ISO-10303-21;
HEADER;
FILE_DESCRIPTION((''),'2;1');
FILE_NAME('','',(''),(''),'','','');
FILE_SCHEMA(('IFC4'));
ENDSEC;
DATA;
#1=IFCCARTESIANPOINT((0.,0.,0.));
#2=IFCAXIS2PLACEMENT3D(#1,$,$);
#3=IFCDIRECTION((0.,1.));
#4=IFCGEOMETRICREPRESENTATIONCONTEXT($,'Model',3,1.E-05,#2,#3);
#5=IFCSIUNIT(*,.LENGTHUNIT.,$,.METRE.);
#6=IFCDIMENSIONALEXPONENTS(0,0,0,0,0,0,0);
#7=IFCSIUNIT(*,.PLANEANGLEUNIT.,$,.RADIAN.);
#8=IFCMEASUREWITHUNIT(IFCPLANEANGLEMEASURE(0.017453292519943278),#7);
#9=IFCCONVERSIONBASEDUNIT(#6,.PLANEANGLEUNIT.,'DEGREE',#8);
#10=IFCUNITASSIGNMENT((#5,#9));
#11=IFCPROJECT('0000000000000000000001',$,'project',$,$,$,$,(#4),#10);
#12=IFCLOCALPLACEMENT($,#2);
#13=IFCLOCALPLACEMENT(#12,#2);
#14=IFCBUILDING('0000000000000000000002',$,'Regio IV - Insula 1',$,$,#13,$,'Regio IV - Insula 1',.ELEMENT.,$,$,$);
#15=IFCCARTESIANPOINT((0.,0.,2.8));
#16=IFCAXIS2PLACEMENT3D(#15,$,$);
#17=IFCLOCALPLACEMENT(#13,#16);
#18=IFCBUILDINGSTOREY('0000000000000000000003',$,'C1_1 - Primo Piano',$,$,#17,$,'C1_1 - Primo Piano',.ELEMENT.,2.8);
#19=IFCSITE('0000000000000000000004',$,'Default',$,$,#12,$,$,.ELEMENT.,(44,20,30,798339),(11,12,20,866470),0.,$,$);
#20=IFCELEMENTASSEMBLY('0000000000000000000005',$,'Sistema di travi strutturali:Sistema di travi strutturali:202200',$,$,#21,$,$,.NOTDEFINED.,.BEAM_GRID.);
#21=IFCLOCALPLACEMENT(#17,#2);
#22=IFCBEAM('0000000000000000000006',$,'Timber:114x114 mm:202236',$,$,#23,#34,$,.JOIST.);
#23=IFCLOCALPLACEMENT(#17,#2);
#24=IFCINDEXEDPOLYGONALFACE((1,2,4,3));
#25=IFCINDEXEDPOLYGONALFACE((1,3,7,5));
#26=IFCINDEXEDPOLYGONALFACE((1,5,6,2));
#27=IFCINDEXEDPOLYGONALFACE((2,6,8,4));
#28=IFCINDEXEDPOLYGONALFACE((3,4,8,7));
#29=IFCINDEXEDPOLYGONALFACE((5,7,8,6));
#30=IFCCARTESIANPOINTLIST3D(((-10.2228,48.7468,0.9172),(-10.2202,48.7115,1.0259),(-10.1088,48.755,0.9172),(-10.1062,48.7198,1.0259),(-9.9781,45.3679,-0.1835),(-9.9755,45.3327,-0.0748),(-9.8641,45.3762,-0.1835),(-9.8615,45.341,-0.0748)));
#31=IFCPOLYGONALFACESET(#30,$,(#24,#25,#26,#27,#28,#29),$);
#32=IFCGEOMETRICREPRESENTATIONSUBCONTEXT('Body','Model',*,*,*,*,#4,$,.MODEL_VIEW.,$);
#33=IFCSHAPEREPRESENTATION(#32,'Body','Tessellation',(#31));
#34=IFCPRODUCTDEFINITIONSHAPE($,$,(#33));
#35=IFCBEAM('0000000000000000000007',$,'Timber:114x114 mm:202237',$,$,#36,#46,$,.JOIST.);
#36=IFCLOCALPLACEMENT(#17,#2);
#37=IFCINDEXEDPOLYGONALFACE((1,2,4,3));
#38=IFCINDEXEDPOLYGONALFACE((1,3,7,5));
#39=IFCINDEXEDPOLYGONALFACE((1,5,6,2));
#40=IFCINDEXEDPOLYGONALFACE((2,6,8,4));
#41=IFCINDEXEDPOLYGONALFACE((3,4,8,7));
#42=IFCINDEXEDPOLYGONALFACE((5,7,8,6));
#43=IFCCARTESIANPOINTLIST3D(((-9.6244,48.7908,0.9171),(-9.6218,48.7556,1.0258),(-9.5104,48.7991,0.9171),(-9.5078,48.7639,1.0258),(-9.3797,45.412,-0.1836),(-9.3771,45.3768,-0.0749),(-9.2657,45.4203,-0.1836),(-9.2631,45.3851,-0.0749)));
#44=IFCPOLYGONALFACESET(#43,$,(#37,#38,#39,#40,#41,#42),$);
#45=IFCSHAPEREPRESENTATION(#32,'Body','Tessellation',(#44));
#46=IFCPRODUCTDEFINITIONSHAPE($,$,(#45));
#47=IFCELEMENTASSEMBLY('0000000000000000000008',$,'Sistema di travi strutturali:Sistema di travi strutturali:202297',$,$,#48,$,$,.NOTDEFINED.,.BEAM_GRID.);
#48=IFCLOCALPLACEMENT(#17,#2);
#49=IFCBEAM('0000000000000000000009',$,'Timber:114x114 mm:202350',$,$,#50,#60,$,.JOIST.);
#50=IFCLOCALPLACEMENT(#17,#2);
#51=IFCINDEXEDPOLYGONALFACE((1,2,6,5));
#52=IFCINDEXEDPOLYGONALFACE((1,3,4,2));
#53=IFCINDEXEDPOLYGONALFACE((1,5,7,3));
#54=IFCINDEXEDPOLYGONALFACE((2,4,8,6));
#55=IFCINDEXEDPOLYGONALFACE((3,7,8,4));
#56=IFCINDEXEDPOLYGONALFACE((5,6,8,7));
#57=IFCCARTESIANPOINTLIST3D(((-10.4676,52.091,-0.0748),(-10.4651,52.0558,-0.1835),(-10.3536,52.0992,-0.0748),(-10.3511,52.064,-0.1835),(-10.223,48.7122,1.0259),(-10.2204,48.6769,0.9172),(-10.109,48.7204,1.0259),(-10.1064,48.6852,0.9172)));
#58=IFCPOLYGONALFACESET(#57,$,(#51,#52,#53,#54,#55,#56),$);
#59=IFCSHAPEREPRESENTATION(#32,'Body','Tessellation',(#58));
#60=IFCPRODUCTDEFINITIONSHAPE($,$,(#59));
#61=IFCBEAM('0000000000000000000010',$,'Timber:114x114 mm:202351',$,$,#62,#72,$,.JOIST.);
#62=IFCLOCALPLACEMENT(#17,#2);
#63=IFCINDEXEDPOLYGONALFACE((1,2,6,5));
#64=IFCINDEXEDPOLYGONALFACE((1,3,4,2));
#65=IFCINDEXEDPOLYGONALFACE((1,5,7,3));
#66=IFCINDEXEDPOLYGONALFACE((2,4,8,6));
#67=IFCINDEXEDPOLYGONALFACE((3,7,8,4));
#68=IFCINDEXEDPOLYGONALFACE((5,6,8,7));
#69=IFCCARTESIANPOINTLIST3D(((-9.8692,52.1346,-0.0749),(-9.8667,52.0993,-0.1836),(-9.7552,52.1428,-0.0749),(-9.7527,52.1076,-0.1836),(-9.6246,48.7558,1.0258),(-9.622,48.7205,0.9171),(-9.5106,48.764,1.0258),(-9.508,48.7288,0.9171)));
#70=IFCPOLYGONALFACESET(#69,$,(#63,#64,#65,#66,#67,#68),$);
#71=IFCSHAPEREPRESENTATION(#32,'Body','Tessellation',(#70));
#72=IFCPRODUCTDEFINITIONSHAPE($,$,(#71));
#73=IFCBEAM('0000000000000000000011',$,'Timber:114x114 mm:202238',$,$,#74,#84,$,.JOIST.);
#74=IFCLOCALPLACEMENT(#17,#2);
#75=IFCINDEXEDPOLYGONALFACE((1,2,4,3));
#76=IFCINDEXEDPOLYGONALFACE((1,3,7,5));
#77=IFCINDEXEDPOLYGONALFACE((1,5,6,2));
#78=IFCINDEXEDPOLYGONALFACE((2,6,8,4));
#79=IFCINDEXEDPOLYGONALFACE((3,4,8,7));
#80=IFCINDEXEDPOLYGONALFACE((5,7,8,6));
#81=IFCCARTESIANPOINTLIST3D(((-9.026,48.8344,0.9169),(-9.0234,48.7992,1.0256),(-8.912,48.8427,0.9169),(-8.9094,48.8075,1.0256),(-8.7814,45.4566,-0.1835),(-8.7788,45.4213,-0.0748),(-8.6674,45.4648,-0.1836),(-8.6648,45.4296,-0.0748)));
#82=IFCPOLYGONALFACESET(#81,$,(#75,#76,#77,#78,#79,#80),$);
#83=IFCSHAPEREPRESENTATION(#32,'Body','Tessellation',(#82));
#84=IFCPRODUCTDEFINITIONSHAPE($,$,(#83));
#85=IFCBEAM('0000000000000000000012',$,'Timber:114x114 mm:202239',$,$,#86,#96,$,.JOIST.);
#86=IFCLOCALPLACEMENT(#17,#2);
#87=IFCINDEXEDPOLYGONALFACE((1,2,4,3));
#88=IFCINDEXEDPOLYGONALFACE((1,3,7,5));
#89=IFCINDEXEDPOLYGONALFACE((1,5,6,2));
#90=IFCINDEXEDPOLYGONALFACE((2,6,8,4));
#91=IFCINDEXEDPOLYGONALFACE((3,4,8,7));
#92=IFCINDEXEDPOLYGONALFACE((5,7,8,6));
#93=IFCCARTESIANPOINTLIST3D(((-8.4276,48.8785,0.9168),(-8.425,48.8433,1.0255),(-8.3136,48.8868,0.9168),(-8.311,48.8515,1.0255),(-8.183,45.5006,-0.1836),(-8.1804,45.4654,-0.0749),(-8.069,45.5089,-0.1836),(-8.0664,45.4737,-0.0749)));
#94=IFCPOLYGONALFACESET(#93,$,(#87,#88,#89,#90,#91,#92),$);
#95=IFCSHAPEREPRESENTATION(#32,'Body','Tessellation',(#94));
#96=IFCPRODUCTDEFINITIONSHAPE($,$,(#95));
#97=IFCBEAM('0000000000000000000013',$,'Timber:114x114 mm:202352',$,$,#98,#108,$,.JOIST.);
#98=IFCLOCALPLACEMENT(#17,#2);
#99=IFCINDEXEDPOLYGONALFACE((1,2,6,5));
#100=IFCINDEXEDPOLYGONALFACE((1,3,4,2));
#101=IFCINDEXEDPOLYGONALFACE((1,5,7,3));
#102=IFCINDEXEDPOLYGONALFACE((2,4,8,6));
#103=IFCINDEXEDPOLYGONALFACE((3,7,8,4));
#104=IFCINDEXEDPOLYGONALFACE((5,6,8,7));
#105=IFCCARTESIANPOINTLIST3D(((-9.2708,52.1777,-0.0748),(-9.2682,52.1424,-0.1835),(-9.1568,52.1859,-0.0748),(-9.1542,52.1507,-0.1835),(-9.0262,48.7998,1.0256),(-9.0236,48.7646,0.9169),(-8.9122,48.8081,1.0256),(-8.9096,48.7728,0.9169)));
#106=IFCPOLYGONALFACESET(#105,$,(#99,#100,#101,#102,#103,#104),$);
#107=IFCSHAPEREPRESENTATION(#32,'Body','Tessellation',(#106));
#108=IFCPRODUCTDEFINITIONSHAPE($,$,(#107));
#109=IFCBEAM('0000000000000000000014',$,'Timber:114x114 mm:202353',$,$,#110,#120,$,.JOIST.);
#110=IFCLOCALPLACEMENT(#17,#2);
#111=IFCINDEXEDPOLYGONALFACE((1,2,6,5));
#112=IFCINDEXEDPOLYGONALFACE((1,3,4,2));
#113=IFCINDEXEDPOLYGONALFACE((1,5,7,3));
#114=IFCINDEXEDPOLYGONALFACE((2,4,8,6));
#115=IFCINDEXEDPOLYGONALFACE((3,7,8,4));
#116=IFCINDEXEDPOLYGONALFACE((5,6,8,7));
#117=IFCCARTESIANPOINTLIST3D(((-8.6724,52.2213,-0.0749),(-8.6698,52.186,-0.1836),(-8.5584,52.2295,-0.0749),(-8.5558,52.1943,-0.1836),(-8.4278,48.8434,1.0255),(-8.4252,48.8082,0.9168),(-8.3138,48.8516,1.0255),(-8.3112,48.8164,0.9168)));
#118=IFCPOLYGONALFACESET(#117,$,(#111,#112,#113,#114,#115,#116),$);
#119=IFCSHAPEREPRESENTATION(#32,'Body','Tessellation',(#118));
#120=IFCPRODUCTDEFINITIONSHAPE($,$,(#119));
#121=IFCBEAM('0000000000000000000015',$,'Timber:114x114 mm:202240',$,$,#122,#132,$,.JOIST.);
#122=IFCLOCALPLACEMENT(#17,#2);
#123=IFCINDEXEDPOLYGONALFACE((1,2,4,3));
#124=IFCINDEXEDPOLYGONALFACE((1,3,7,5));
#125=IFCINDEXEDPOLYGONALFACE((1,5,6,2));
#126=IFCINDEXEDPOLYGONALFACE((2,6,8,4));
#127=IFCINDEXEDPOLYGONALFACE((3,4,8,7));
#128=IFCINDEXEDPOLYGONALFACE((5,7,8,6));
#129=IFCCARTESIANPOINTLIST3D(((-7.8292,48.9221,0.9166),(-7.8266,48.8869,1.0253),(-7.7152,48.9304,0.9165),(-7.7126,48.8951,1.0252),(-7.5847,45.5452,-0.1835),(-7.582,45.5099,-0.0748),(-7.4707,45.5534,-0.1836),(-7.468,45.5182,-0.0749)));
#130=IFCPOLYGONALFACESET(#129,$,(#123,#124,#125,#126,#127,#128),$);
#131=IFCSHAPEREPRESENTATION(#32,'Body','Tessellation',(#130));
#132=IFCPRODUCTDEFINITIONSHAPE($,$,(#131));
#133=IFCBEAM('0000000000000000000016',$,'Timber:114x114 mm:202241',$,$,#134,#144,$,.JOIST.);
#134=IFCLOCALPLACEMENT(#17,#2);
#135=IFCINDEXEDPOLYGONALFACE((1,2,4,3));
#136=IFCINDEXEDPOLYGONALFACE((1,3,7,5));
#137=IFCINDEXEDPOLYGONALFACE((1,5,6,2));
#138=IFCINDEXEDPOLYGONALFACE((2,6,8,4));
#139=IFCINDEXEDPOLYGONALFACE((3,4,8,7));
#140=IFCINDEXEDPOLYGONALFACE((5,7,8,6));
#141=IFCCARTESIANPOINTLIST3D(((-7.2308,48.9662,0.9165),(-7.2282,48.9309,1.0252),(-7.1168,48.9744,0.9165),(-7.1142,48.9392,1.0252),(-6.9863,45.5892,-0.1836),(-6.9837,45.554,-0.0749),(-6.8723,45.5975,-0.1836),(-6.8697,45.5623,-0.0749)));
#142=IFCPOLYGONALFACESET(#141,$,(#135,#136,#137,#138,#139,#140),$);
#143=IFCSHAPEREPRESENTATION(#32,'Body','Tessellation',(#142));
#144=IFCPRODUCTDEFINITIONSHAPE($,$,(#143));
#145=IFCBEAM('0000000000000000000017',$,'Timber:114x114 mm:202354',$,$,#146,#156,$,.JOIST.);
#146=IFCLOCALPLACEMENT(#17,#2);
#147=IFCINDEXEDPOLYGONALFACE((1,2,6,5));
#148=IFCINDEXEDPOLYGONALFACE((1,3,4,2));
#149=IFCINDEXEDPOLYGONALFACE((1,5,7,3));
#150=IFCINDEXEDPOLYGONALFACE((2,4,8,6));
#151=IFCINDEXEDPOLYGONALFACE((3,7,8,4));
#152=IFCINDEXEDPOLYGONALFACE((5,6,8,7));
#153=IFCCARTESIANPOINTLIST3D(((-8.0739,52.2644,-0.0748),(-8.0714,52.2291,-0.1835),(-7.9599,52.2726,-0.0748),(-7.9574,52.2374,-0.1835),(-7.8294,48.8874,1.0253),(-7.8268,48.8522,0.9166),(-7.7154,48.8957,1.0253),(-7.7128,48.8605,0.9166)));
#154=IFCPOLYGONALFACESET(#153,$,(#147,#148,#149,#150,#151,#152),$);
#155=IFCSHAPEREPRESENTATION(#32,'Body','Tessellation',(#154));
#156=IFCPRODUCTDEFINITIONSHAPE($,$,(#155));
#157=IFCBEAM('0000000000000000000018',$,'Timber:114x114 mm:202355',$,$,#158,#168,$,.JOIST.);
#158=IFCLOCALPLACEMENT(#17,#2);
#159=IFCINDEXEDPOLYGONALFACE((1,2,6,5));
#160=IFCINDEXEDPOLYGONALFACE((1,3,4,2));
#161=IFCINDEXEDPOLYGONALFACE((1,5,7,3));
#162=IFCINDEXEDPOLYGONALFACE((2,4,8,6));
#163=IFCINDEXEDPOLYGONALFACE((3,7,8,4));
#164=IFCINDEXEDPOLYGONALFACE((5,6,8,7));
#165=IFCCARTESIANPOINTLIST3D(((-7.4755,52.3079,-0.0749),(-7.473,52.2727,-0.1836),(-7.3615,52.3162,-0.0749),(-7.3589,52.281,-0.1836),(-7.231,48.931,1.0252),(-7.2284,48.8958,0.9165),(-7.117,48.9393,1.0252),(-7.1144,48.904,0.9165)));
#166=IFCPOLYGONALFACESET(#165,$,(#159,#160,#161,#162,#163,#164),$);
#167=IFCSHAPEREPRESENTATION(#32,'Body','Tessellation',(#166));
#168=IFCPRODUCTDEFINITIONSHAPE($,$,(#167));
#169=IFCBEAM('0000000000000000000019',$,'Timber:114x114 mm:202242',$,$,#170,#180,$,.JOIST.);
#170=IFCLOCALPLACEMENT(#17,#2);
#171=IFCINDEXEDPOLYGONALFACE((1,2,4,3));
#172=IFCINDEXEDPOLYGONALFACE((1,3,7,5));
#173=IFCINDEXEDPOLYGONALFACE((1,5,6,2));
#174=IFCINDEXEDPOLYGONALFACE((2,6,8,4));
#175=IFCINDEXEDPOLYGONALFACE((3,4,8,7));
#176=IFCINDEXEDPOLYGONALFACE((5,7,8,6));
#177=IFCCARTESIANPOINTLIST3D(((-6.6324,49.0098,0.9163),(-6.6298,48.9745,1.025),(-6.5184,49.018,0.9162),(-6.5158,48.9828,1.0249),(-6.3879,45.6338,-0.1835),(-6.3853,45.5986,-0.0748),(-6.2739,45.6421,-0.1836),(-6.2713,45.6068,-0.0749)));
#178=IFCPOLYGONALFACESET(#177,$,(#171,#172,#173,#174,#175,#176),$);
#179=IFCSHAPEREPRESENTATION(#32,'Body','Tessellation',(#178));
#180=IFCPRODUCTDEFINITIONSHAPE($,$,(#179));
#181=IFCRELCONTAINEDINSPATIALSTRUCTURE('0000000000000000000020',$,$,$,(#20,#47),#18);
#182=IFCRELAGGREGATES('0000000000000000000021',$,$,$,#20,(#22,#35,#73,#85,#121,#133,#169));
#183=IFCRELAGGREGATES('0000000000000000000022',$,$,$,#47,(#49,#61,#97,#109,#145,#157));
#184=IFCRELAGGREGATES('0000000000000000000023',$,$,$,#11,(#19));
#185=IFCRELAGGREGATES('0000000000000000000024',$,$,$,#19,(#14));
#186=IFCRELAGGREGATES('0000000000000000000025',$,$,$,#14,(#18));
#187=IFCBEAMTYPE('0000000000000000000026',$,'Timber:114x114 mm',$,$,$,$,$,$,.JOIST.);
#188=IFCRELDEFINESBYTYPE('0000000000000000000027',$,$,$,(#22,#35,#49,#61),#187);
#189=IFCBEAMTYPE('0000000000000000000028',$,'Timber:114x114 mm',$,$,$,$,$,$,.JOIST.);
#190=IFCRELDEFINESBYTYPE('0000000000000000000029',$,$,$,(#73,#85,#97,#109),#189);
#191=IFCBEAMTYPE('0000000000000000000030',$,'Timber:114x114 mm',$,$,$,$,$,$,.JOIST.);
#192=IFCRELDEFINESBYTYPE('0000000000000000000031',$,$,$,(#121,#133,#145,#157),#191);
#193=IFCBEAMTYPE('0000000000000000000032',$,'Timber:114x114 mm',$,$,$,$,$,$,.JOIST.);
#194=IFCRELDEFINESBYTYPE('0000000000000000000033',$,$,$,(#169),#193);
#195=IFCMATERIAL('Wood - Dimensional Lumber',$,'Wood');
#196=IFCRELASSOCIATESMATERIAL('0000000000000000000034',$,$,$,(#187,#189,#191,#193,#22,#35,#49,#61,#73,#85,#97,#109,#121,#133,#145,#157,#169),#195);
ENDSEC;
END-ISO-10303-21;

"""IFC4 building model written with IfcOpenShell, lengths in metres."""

from ifc_helpers import new_model, entity, si_unit, converted_unit, direction, frame, origin, origin_2d_with_axis, place, context, subcontext, project, spatial, rectangle, extrude, source, transform, mapped, material, material_profile, profile_set, profile_usage, type_object, type_shapes, element, aggregate, save


model = new_model("IFC4")

# Units and contexts
model_context = context("Model", 3, precision=1e-05, world=origin(), true_north=direction((0.0, 1.0)))
body_context = subcontext(model_context, "Body", "Model", "MODEL_VIEW")
ifc_project = project(units=[si_unit("LENGTHUNIT", "METRE"), converted_unit("PLANEANGLEUNIT", "DEGREE", entity("IfcPlaneAngleMeasure", 0.017453292519943278), si_unit("PLANEANGLEUNIT", "RADIAN"), dimensions=[0, 0, 0, 0, 0, 0, 0])], contexts=[model_context])

# Site, building, storey
site_placement = place(None, origin())
site = spatial("IfcSite", under=ifc_project, at=site_placement, Name="Default", CompositionType="ELEMENT", RefLatitude=(44, 20, 30, 798339), RefLongitude=(11, 12, 20, 866470), RefElevation=0.0)
building_placement = place(site_placement, origin())
building = spatial("IfcBuilding", under=site, at=building_placement, Name="Regio IV - Insula 1", LongName="Regio IV - Insula 1", CompositionType="ELEMENT")
storey_placement = place(building_placement, frame((0.0, 0.0, 2.8)))
storey = spatial("IfcBuildingStorey", under=building, at=storey_placement, Name="C1_1 - Primo Piano", LongName="C1_1 - Primo Piano", CompositionType="ELEMENT", Elevation=2.8)

# Element assemblies, beams
assembly_1_placement = place(storey_placement, origin())
assembly_1 = element("IfcElementAssembly", 1, at=assembly_1_placement, inside=storey, Name="Sistema di travi strutturali:Sistema di travi strutturali:202200", AssemblyPlace="NOTDEFINED", PredefinedType="BEAM_GRID")
ifc_material = material(Name="Wood - Dimensional Lumber", Category="Wood")
ifc_material_profile = material_profile(ifc_material, rectangle(XDim=5.294, YDim=0.1143, at=origin_2d_with_axis()), Name="114x114 mm")
ifc_profile_set = profile_set([ifc_material_profile], Name="114x114 mm")
ifc_profile_usage = profile_usage(ifc_profile_set, cardinal=8)
beam_type_1 = type_object("IfcBeamType", Name="Timber:114x114 mm", PredefinedType="JOIST", material=ifc_profile_set)
shared_shape_1 = source(origin(), body_context, "Body", "SweptSolid", [
    extrude(rectangle(XDim=3.562, YDim=0.1143, at=origin_2d_with_axis()), frame((0.0, 0.0, -0.0572), z_axis=(0.0, 0.0, 1.0), x_axis=(-1.0, 0.0, 0.0)), (0.0, 0.0, 1.0), 0.1143),
])
type_shapes(beam_type_1, [shared_shape_1])
beam_1_placement = place(assembly_1_placement, frame((-10.0421, 47.0439, 0.4212), z_axis=(0.022823, -0.308173, 0.951057), x_axis=(0.068685, -0.948573, -0.309017)))
beam_1 = element("IfcBeam", 2, at=beam_1_placement, type_object=beam_type_1, material=ifc_profile_usage, Name="Timber:114x114 mm:202236", PredefinedType="JOIST", context=body_context, shape_type="MappedRepresentation", body=[
    mapped(shared_shape_1, transform((0.0, 0.0, 0.0), scale=1.0)),
])
beam_2_placement = place(assembly_1_placement, frame((-9.4438, 47.088, 0.4211), z_axis=(0.022823, -0.308173, 0.951057), x_axis=(0.068685, -0.948573, -0.309017)))
beam_2 = element("IfcBeam", 3, at=beam_2_placement, type_object=beam_type_1, material=ifc_profile_usage, Name="Timber:114x114 mm:202237", PredefinedType="JOIST", context=body_context, shape_type="MappedRepresentation", body=[
    mapped(shared_shape_1, transform((0.0, 0.0, 0.0), scale=1.0)),
])
assembly_2_placement = place(storey_placement, origin())
assembly_2 = element("IfcElementAssembly", 4, at=assembly_2_placement, inside=storey, Name="Sistema di travi strutturali:Sistema di travi strutturali:202297", AssemblyPlace="NOTDEFINED", PredefinedType="BEAM_GRID")
beam_3_placement = place(assembly_2_placement, frame((-10.287, 50.3881, 0.4212), z_axis=(-0.022317, 0.30821, 0.951057), x_axis=(0.068685, -0.948573, 0.309017)))
beam_3 = element("IfcBeam", 5, at=beam_3_placement, type_object=beam_type_1, material=ifc_profile_usage, Name="Timber:114x114 mm:202350", PredefinedType="JOIST", context=body_context, shape_type="MappedRepresentation", body=[
    mapped(shared_shape_1, transform((0.0, 0.0, 0.0), scale=1.0)),
])
beam_4_placement = place(assembly_2_placement, frame((-9.6886, 50.4317, 0.4211), z_axis=(-0.022317, 0.30821, 0.951057), x_axis=(0.068685, -0.948573, 0.309017)))
beam_4 = element("IfcBeam", 6, at=beam_4_placement, type_object=beam_type_1, material=ifc_profile_usage, Name="Timber:114x114 mm:202351", PredefinedType="JOIST", context=body_context, shape_type="MappedRepresentation", body=[
    mapped(shared_shape_1, transform((0.0, 0.0, 0.0), scale=1.0)),
])

# Beams
beam_type_2 = type_object("IfcBeamType", Name="Timber:114x114 mm", PredefinedType="JOIST", material=ifc_profile_set)
shared_shape_2 = source(origin(), body_context, "Body", "SweptSolid", [
    extrude(rectangle(XDim=3.561, YDim=0.1143, at=origin_2d_with_axis()), frame((0.0, 0.0, -0.0572), z_axis=(0.0, 0.0, 1.0), x_axis=(-1.0, 0.0, 0.0)), (0.0, 0.0, 1.0), 0.1143),
])
type_shapes(beam_type_2, [shared_shape_2])
beam_5_placement = place(assembly_1_placement, frame((-8.8454, 47.132, 0.421), z_axis=(0.022823, -0.308173, 0.951057), x_axis=(0.068685, -0.948573, -0.309017)))
beam_5 = element("IfcBeam", 7, at=beam_5_placement, type_object=beam_type_2, material=ifc_profile_usage, Name="Timber:114x114 mm:202238", PredefinedType="JOIST", context=body_context, shape_type="MappedRepresentation", body=[
    mapped(shared_shape_2, transform((0.0, 0.0, 0.0), scale=1.0)),
])
beam_6_placement = place(assembly_1_placement, frame((-8.247, 47.1761, 0.4209), z_axis=(0.022823, -0.308173, 0.951057), x_axis=(0.068685, -0.948573, -0.309017)))
beam_6 = element("IfcBeam", 8, at=beam_6_placement, type_object=beam_type_2, material=ifc_profile_usage, Name="Timber:114x114 mm:202239", PredefinedType="JOIST", context=body_context, shape_type="MappedRepresentation", body=[
    mapped(shared_shape_2, transform((0.0, 0.0, 0.0), scale=1.0)),
])
beam_7_placement = place(assembly_2_placement, frame((-9.0902, 50.4753, 0.421), z_axis=(-0.022317, 0.30821, 0.951057), x_axis=(0.068685, -0.948573, 0.309017)))
beam_7 = element("IfcBeam", 9, at=beam_7_placement, type_object=beam_type_2, material=ifc_profile_usage, Name="Timber:114x114 mm:202352", PredefinedType="JOIST", context=body_context, shape_type="MappedRepresentation", body=[
    mapped(shared_shape_2, transform((0.0, 0.0, 0.0), scale=1.0)),
])
beam_8_placement = place(assembly_2_placement, frame((-8.4918, 50.5188, 0.4209), z_axis=(-0.022317, 0.30821, 0.951057), x_axis=(0.068685, -0.948573, 0.309017)))
beam_8 = element("IfcBeam", 10, at=beam_8_placement, type_object=beam_type_2, material=ifc_profile_usage, Name="Timber:114x114 mm:202353", PredefinedType="JOIST", context=body_context, shape_type="MappedRepresentation", body=[
    mapped(shared_shape_2, transform((0.0, 0.0, 0.0), scale=1.0)),
])
beam_type_3 = type_object("IfcBeamType", Name="Timber:114x114 mm", PredefinedType="JOIST", material=ifc_profile_set)
shared_shape_3 = source(origin(), body_context, "Body", "SweptSolid", [
    extrude(rectangle(XDim=3.56, YDim=0.1143, at=origin_2d_with_axis()), frame((0.0, 0.0, -0.0572), z_axis=(0.0, 0.0, 1.0), x_axis=(-1.0, 0.0, 0.0)), (0.0, 0.0, 1.0), 0.1143),
])
type_shapes(beam_type_3, [shared_shape_3])
beam_9_placement = place(assembly_1_placement, frame((-7.6486, 47.2202, 0.4209), z_axis=(0.022823, -0.308173, 0.951057), x_axis=(0.068685, -0.948573, -0.309017)))
beam_9 = element("IfcBeam", 11, at=beam_9_placement, type_object=beam_type_3, material=ifc_profile_usage, Name="Timber:114x114 mm:202240", PredefinedType="JOIST", context=body_context, shape_type="MappedRepresentation", body=[
    mapped(shared_shape_3, transform((0.0, 0.0, 0.0), scale=1.0)),
])
beam_10_placement = place(assembly_1_placement, frame((-7.0502, 47.2642, 0.4208), z_axis=(0.022823, -0.308173, 0.951057), x_axis=(0.068685, -0.948573, -0.309017)))
beam_10 = element("IfcBeam", 12, at=beam_10_placement, type_object=beam_type_3, material=ifc_profile_usage, Name="Timber:114x114 mm:202241", PredefinedType="JOIST", context=body_context, shape_type="MappedRepresentation", body=[
    mapped(shared_shape_3, transform((0.0, 0.0, 0.0), scale=1.0)),
])
beam_11_placement = place(assembly_2_placement, frame((-7.8934, 50.5624, 0.4209), z_axis=(-0.022317, 0.30821, 0.951057), x_axis=(0.068685, -0.948573, 0.309017)))
beam_11 = element("IfcBeam", 13, at=beam_11_placement, type_object=beam_type_3, material=ifc_profile_usage, Name="Timber:114x114 mm:202354", PredefinedType="JOIST", context=body_context, shape_type="MappedRepresentation", body=[
    mapped(shared_shape_3, transform((0.0, 0.0, 0.0), scale=1.0)),
])
beam_12_placement = place(assembly_2_placement, frame((-7.295, 50.606, 0.4208), z_axis=(-0.022317, 0.30821, 0.951057), x_axis=(0.068685, -0.948573, 0.309017)))
beam_12 = element("IfcBeam", 14, at=beam_12_placement, type_object=beam_type_3, material=ifc_profile_usage, Name="Timber:114x114 mm:202355", PredefinedType="JOIST", context=body_context, shape_type="MappedRepresentation", body=[
    mapped(shared_shape_3, transform((0.0, 0.0, 0.0), scale=1.0)),
])
beam_type_4 = type_object("IfcBeamType", Name="Timber:114x114 mm", PredefinedType="JOIST", material=ifc_profile_set)
shared_shape_4 = source(origin(), body_context, "Body", "SweptSolid", [
    extrude(rectangle(XDim=3.559, YDim=0.1143, at=origin_2d_with_axis()), frame((0.0, 0.0, -0.0572), z_axis=(0.0, 0.0, 1.0), x_axis=(-1.0, 0.0, 0.0)), (0.0, 0.0, 1.0), 0.1143),
])
type_shapes(beam_type_4, [shared_shape_4])
beam_13_placement = place(assembly_1_placement, frame((-6.4519, 47.3083, 0.4207), z_axis=(0.022823, -0.308173, 0.951057), x_axis=(0.068685, -0.948573, -0.309017)))
beam_13 = element("IfcBeam", 15, at=beam_13_placement, type_object=beam_type_4, material=ifc_profile_usage, Name="Timber:114x114 mm:202242", PredefinedType="JOIST", context=body_context, shape_type="MappedRepresentation", body=[
    mapped(shared_shape_4, transform((0.0, 0.0, 0.0), scale=1.0)),
])
aggregate(assembly_1, [beam_1, beam_2, beam_5, beam_6, beam_9, beam_10, beam_13])
aggregate(assembly_2, [beam_3, beam_4, beam_7, beam_8, beam_11, beam_12])

save(model, "model.ifc")
